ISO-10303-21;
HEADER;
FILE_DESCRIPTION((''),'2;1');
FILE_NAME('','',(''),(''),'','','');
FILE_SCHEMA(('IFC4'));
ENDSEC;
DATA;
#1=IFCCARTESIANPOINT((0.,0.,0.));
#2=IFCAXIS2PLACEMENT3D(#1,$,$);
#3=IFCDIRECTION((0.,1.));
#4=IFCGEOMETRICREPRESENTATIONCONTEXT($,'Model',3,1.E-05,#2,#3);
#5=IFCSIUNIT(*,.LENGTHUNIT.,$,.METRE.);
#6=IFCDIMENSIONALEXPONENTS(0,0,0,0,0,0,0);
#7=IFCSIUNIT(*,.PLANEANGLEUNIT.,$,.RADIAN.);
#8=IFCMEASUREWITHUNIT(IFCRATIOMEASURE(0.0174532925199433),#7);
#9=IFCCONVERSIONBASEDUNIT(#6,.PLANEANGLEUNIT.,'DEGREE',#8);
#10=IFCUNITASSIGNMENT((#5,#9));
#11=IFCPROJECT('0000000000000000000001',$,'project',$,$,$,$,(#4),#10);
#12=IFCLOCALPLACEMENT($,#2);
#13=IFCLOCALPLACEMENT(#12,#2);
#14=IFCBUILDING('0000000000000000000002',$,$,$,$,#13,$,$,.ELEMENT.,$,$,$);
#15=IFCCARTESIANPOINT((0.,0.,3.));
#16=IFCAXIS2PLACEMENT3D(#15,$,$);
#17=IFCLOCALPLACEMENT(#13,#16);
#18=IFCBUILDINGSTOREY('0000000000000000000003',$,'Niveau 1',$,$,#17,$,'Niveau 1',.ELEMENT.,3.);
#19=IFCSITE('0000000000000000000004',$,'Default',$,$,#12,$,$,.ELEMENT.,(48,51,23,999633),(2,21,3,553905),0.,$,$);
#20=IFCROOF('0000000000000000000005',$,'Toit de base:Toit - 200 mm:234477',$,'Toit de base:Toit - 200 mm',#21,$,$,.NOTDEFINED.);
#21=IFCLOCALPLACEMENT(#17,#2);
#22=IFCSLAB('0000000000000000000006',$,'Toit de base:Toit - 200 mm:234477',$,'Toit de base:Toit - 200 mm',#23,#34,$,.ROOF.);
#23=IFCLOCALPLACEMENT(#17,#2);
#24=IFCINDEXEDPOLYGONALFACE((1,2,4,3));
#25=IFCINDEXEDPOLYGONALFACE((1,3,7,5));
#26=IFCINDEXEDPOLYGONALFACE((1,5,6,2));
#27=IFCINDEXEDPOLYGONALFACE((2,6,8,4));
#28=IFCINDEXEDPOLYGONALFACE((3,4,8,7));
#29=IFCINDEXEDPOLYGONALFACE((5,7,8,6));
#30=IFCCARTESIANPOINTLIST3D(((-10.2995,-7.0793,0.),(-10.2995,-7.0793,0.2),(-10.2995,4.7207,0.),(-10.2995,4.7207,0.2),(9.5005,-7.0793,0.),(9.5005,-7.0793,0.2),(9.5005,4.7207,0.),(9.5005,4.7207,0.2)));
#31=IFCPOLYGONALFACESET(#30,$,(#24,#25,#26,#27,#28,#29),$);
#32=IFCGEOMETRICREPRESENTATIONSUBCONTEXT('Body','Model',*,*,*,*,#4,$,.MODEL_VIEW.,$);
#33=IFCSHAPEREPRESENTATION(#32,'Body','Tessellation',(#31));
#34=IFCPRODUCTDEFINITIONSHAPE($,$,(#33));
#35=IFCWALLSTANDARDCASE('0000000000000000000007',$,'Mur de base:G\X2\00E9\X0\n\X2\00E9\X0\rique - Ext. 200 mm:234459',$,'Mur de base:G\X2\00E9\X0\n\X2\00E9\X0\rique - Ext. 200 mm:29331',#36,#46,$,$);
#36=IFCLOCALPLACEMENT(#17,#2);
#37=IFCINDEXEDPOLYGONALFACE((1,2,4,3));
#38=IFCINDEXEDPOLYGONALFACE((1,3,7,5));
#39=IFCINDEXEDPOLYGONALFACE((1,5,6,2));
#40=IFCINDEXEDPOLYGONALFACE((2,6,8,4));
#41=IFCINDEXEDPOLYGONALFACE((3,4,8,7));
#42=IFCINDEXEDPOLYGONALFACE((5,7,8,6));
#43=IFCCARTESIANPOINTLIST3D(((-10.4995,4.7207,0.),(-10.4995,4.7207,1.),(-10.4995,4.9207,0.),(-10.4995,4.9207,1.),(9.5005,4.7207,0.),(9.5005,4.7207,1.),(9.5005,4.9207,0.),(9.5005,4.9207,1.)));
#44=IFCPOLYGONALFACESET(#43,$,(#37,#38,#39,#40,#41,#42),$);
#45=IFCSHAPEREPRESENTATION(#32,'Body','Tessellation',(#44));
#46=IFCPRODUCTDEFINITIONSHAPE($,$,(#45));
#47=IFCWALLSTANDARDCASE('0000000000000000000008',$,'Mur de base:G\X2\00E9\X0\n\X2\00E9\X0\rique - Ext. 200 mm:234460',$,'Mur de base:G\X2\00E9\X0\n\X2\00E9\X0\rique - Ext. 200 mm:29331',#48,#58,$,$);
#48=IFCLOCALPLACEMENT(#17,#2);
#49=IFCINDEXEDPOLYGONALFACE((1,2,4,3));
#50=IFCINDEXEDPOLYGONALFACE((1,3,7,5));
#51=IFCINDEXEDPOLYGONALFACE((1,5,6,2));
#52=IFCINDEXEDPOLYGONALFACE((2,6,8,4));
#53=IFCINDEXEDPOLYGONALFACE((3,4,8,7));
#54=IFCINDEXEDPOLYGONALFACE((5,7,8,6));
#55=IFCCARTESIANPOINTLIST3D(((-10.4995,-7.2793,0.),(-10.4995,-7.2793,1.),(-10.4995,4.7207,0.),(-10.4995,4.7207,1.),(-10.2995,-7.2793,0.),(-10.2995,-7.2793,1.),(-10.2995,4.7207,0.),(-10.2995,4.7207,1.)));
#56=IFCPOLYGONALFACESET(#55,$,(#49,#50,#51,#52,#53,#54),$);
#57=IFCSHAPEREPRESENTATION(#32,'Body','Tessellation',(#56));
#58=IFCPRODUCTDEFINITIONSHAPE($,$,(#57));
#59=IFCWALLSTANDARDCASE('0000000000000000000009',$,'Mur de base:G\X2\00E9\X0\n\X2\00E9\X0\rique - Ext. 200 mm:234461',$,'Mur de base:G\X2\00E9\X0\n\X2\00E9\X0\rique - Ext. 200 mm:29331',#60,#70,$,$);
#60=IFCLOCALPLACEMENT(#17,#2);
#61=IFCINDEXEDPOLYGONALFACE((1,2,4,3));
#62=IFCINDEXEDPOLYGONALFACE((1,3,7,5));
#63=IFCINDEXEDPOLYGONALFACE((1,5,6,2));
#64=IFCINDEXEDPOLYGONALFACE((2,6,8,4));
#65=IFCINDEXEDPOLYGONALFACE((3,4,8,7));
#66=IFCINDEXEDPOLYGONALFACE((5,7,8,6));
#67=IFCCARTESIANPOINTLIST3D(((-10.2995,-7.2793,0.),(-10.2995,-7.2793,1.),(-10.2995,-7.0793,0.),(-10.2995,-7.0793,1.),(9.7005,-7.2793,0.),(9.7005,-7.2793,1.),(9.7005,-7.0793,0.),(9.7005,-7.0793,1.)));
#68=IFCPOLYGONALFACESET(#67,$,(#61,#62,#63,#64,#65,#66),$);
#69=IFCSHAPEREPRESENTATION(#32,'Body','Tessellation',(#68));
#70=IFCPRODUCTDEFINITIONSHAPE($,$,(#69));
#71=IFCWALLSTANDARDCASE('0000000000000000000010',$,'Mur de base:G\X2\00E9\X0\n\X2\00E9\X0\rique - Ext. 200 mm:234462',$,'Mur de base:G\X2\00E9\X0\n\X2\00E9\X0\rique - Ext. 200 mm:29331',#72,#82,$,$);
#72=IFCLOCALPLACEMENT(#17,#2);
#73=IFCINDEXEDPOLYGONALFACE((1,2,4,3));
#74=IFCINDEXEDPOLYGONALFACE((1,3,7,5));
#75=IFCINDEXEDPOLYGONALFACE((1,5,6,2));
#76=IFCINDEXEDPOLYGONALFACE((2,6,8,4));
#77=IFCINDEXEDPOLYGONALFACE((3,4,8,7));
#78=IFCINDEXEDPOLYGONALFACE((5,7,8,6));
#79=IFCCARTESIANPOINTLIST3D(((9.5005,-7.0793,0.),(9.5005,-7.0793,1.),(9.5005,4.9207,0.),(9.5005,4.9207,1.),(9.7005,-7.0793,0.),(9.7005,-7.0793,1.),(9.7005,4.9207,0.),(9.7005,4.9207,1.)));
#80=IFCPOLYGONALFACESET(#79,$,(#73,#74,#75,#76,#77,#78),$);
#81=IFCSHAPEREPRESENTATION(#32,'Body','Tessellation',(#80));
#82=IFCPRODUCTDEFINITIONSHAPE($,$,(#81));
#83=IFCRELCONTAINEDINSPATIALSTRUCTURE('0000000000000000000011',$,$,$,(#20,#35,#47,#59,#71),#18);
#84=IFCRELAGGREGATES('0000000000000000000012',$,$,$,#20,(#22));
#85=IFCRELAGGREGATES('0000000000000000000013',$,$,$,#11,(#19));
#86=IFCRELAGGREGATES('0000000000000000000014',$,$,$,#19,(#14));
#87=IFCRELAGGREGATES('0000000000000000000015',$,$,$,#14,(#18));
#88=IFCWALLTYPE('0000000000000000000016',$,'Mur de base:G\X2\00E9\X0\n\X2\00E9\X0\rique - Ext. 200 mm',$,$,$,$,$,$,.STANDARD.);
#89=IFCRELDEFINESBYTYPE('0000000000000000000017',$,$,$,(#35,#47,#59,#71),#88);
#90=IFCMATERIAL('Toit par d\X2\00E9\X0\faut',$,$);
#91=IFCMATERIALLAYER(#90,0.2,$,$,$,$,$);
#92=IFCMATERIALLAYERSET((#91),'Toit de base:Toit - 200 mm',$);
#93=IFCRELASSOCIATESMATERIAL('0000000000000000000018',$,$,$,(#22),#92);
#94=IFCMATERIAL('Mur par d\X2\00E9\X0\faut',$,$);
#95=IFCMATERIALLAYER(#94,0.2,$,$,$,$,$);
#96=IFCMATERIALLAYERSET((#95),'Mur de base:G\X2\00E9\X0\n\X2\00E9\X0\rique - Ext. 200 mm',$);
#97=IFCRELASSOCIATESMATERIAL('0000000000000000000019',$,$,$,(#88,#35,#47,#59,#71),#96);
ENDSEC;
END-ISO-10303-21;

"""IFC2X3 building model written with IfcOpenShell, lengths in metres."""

from ifc_helpers import new_model, entity, si_unit, converted_unit, direction, frame, frame_2d, origin, origin_2d_with_axis, place, context, subcontext, project, spatial, rectangle, extrude, material, layer, layer_set, layer_usage, type_object, element, aggregate, save


model = new_model("IFC2X3")

# Units and contexts
model_context = context("Model", 3, precision=1e-05, world=origin(), true_north=direction((0.0, 1.0)))
body_context = subcontext(model_context, "Body", "Model", "MODEL_VIEW")
ifc_project = project(units=[si_unit("LENGTHUNIT", "METRE"), converted_unit("PLANEANGLEUNIT", "DEGREE", entity("IfcRatioMeasure", 0.0174532925199433), si_unit("PLANEANGLEUNIT", "RADIAN"), dimensions=[0, 0, 0, 0, 0, 0, 0])], contexts=[model_context])

# Site, building, storey
site_placement = place(None, origin())
site = spatial("IfcSite", under=ifc_project, at=site_placement, Name="Default", CompositionType="ELEMENT", RefLatitude=(48, 51, 23, 999633), RefLongitude=(2, 21, 3, 553905), RefElevation=0.0)
building_placement = place(site_placement, origin())
building = spatial("IfcBuilding", under=site, at=building_placement, CompositionType="ELEMENT")
storey_placement = place(building_placement, frame((0.0, 0.0, 3.0)))
storey = spatial("IfcBuildingStorey", under=building, at=storey_placement, Name="Niveau 1", LongName="Niveau 1", CompositionType="ELEMENT", Elevation=3.0)

# Roof, slab
roof_placement = place(storey_placement, frame((-10.2995, -7.0793, 0.0)))
roof = element("IfcRoof", 1, at=roof_placement, inside=storey, Name="Toit de base:Toit - 200 mm:234477", ObjectType="Toit de base:Toit - 200 mm", ShapeType="NOTDEFINED")
ifc_material_1 = material(Name="Toit par défaut")
ifc_layer_1 = layer(ifc_material_1, 0.2)
ifc_layer_set_1 = layer_set([ifc_layer_1], Name="Toit de base:Toit - 200 mm")
slab_placement = place(roof_placement, origin())
slab = element("IfcSlab", 2, at=slab_placement, material=ifc_layer_set_1, Name="Toit de base:Toit - 200 mm:234477", ObjectType="Toit de base:Toit - 200 mm", PredefinedType="ROOF", context=body_context, shape_type="SweptSolid", body=[
    extrude(rectangle(XDim=19.8, YDim=11.8, at=origin_2d_with_axis()), frame((9.9, 5.9, 0.0)), (0.0, 0.0, 1.0), 0.2),
])
aggregate(roof, [slab])

# Walls
ifc_material_2 = material(Name="Mur par défaut")
ifc_layer_2 = layer(ifc_material_2, 0.2)
ifc_layer_set_2 = layer_set([ifc_layer_2], Name="Mur de base:Générique - Ext. 200 mm")
ifc_layer_usage_1 = layer_usage(ifc_layer_set_2, "AXIS2", "NEGATIVE", 0.1)
wall_type = type_object("IfcWallType", Name="Mur de base:Générique - Ext. 200 mm", PredefinedType="STANDARD", material=ifc_layer_set_2)
wall_1_placement = place(storey_placement, frame((-10.4995, 4.8207, 0.0)))
element("IfcWallStandardCase", 3, at=wall_1_placement, inside=storey, type_object=wall_type, material=ifc_layer_usage_1, Name="Mur de base:Générique - Ext. 200 mm:234459", ObjectType="Mur de base:Générique - Ext. 200 mm:29331", context=body_context, shape_type="SweptSolid", body=[
    extrude(rectangle(XDim=20.0, YDim=0.2, at=frame_2d((10.0, 0.0), x_axis=(-1.0, 0.0))), origin(), (0.0, 0.0, 1.0), 1.0),
])
ifc_layer_usage_2 = layer_usage(ifc_layer_set_2, "AXIS2", "NEGATIVE", 0.1)
wall_2_placement = place(storey_placement, frame((-10.3995, -7.2793, 0.0), z_axis=(0.0, 0.0, 1.0), x_axis=(0.0, 1.0, 0.0)))
element("IfcWallStandardCase", 4, at=wall_2_placement, inside=storey, type_object=wall_type, material=ifc_layer_usage_2, Name="Mur de base:Générique - Ext. 200 mm:234460", ObjectType="Mur de base:Générique - Ext. 200 mm:29331", context=body_context, shape_type="SweptSolid", body=[
    extrude(rectangle(XDim=12.0, YDim=0.2, at=frame_2d((6.0, 0.0), x_axis=(-1.0, 0.0))), origin(), (0.0, 0.0, 1.0), 1.0),
])
ifc_layer_usage_3 = layer_usage(ifc_layer_set_2, "AXIS2", "NEGATIVE", 0.1)
wall_3_placement = place(storey_placement, frame((9.7005, -7.1793, 0.0), z_axis=(0.0, 0.0, 1.0), x_axis=(-1.0, 0.0, 0.0)))
element("IfcWallStandardCase", 5, at=wall_3_placement, inside=storey, type_object=wall_type, material=ifc_layer_usage_3, Name="Mur de base:Générique - Ext. 200 mm:234461", ObjectType="Mur de base:Générique - Ext. 200 mm:29331", context=body_context, shape_type="SweptSolid", body=[
    extrude(rectangle(XDim=20.0, YDim=0.2, at=frame_2d((10.0, 0.0), x_axis=(-1.0, 0.0))), origin(), (0.0, 0.0, 1.0), 1.0),
])
ifc_layer_usage_4 = layer_usage(ifc_layer_set_2, "AXIS2", "NEGATIVE", 0.1)
wall_4_placement = place(storey_placement, frame((9.6005, 4.9207, 0.0), z_axis=(0.0, 0.0, 1.0), x_axis=(0.0, -1.0, 0.0)))
element("IfcWallStandardCase", 6, at=wall_4_placement, inside=storey, type_object=wall_type, material=ifc_layer_usage_4, Name="Mur de base:Générique - Ext. 200 mm:234462", ObjectType="Mur de base:Générique - Ext. 200 mm:29331", context=body_context, shape_type="SweptSolid", body=[
    extrude(rectangle(XDim=12.0, YDim=0.2, at=frame_2d((6.0, 0.0), x_axis=(-1.0, 0.0))), origin(), (0.0, 0.0, 1.0), 1.0),
])

save(model, "model.ifc")
